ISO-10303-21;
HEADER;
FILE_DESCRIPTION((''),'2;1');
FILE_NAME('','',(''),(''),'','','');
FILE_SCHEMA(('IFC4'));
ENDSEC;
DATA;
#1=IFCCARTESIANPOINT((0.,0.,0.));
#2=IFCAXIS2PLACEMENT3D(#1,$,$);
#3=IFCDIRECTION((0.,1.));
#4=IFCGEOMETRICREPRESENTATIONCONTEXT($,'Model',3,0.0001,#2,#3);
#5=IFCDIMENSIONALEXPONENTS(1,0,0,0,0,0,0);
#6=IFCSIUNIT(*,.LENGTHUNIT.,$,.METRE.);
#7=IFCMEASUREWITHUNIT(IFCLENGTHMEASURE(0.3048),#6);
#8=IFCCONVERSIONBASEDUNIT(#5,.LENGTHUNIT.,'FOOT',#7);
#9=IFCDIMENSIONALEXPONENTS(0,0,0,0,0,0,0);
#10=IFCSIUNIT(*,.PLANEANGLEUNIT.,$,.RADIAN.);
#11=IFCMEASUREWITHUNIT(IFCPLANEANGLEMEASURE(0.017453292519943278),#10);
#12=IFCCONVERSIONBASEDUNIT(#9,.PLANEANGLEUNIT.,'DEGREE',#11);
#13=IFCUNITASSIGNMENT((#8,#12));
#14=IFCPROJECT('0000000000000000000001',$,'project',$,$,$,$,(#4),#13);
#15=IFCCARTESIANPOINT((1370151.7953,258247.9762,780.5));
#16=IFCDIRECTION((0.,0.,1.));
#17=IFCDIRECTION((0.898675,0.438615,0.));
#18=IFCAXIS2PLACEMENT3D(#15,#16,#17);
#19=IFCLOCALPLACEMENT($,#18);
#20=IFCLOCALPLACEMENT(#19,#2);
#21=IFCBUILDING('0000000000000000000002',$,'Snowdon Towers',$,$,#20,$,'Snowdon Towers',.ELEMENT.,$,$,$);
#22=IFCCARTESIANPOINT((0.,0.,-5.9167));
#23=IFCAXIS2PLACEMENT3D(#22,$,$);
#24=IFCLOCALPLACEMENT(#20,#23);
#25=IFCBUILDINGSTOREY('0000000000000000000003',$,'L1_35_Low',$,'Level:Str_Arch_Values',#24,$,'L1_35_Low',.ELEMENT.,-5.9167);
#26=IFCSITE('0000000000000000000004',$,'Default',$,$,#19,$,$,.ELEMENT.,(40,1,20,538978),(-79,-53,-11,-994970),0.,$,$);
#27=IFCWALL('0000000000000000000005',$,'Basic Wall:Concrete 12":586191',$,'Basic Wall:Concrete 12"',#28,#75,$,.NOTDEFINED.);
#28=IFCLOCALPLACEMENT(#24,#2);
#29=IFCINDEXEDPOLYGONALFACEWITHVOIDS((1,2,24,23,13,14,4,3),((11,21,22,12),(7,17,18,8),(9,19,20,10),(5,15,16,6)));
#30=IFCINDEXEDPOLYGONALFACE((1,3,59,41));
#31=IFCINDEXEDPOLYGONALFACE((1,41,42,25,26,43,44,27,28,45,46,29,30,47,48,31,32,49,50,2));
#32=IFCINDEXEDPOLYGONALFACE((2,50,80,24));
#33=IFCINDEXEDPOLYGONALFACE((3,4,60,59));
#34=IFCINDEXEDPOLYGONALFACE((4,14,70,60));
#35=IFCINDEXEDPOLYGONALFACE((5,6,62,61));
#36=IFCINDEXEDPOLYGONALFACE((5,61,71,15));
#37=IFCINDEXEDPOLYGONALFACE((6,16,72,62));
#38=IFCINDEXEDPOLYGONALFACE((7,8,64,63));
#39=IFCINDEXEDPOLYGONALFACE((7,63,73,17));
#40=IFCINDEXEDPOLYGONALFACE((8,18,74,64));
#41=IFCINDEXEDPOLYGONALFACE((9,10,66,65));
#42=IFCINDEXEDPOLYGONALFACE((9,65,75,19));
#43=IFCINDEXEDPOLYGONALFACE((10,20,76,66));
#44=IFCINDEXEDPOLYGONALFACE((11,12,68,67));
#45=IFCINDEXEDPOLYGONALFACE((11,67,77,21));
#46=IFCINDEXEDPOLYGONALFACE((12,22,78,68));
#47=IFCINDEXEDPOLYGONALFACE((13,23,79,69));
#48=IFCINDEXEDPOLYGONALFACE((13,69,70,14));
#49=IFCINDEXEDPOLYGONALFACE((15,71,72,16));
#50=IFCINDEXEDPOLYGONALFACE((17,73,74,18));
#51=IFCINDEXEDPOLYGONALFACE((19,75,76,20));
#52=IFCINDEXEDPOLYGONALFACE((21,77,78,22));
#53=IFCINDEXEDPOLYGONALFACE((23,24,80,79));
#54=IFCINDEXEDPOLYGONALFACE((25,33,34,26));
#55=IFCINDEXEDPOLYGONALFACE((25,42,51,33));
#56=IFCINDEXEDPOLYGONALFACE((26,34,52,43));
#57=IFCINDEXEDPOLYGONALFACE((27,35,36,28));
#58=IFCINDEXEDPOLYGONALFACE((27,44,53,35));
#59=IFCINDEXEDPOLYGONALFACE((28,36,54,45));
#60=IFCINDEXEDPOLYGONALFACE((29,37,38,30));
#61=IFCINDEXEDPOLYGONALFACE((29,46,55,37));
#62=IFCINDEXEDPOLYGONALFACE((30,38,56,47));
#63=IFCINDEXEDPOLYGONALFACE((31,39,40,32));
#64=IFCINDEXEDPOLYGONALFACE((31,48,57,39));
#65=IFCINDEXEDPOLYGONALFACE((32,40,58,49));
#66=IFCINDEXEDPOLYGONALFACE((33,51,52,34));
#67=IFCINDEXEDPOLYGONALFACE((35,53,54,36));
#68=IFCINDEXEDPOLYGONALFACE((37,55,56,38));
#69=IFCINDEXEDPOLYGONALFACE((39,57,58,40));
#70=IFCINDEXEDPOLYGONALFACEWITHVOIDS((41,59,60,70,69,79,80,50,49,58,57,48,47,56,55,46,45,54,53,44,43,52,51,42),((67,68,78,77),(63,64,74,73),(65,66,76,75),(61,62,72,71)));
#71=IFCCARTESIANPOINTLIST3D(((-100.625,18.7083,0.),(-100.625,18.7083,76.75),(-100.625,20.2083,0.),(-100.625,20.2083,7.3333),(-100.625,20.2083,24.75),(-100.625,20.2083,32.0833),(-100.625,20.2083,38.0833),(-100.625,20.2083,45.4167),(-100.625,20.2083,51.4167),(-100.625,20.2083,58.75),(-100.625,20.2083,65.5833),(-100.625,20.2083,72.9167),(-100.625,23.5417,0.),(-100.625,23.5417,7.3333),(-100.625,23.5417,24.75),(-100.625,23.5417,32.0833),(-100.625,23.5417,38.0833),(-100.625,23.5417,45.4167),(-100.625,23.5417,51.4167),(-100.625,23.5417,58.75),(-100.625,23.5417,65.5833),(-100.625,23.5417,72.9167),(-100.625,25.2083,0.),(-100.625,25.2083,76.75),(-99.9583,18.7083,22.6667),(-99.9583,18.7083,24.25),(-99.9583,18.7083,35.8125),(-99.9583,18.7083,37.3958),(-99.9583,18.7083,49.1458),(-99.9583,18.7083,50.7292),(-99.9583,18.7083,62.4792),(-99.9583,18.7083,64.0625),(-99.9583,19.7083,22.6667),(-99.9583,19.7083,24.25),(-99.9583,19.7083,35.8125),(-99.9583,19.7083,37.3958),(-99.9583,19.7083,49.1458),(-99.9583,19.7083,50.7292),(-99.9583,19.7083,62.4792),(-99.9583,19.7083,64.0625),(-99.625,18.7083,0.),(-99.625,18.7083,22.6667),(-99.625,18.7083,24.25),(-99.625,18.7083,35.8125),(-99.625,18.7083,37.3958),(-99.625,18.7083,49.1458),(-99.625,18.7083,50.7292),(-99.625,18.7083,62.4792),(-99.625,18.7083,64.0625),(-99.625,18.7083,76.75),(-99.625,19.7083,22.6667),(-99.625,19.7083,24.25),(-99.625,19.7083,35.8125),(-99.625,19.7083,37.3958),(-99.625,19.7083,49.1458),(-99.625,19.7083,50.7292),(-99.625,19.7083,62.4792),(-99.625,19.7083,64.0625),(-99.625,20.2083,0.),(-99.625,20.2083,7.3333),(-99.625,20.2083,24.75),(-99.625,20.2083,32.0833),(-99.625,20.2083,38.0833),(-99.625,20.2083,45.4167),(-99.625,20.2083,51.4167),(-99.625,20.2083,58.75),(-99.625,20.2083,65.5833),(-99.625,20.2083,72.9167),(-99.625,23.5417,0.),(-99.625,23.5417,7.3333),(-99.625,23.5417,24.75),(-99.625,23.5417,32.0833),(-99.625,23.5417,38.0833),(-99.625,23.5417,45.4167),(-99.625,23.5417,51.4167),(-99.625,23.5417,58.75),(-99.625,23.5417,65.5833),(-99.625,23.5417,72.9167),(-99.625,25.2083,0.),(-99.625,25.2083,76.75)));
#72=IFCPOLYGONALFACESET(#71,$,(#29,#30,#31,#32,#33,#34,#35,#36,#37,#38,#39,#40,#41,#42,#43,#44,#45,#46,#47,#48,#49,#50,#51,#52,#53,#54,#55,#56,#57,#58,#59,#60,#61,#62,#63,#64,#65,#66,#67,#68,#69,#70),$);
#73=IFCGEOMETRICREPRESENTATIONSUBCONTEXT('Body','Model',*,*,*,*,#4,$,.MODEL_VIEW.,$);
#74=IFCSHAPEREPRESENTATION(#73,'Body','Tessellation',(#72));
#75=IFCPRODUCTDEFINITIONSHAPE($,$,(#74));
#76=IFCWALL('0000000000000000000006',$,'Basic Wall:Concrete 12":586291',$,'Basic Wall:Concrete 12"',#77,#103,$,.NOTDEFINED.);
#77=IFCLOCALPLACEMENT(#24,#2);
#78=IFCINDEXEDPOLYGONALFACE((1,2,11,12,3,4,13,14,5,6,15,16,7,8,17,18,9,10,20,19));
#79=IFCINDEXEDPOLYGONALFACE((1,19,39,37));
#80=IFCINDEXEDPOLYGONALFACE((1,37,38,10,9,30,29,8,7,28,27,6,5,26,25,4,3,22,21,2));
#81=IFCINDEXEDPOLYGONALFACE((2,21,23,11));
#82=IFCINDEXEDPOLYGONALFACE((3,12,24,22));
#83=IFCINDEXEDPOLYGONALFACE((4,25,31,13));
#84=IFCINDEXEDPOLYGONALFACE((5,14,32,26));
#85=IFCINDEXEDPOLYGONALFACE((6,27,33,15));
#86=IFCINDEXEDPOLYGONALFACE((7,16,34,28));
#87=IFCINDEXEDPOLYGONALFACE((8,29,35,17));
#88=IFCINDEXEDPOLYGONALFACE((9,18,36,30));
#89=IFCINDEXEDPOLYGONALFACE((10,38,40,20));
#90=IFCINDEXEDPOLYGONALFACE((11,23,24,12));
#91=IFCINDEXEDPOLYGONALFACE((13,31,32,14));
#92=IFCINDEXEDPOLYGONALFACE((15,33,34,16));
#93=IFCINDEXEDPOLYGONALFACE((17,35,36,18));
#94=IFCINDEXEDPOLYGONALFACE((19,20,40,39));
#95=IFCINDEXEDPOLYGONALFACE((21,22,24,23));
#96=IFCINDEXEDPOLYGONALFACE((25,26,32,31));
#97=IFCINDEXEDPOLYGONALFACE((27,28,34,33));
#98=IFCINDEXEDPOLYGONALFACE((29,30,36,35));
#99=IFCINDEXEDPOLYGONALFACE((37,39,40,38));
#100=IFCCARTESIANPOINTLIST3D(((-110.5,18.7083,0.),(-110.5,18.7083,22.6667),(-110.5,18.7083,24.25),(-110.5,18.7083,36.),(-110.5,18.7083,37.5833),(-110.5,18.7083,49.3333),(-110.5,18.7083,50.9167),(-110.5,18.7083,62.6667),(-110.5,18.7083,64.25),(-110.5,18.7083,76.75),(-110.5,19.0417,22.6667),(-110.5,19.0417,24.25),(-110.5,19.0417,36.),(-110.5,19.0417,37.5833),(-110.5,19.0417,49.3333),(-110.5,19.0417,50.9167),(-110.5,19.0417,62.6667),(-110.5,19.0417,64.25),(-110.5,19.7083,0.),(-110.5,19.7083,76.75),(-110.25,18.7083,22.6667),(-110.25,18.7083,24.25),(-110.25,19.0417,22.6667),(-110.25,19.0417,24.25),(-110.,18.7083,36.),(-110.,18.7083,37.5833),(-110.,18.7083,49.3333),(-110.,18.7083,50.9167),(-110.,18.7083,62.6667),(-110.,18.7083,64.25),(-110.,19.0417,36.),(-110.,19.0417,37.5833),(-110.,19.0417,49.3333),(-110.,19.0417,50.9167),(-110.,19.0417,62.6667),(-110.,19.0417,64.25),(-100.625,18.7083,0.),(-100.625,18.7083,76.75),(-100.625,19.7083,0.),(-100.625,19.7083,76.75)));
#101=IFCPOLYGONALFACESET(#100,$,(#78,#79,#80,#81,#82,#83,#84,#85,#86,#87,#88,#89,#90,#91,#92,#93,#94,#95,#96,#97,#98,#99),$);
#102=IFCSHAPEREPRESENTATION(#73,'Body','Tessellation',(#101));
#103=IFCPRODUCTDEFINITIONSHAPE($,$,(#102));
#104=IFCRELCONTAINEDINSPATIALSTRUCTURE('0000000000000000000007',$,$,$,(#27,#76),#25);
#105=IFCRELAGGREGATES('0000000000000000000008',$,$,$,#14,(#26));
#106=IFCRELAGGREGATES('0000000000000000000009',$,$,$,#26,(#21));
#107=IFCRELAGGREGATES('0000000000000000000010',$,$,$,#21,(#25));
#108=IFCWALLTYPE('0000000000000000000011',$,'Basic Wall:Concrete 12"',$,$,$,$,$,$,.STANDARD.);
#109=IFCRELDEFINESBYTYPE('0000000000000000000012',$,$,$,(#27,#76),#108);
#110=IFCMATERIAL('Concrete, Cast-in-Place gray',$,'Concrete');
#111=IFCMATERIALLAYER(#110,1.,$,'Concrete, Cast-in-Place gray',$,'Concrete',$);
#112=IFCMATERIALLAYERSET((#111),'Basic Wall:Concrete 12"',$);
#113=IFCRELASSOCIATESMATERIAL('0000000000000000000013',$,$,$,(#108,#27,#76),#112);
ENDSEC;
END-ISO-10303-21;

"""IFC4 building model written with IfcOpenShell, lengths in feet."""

from ifc_helpers import new_model, entity, si_unit, converted_unit, direction, frame, frame_2d, origin, place, context, subcontext, project, spatial, rectangle, extrude, material, layer, layer_set, layer_usage, type_object, element, save


model = new_model("IFC4")

# Units and contexts
model_context = context("Model", 3, precision=0.0001, world=origin(), true_north=direction((0.0, 1.0)))
body_context = subcontext(model_context, "Body", "Model", "MODEL_VIEW")
ifc_project = project(units=[converted_unit("LENGTHUNIT", "FOOT", entity("IfcLengthMeasure", 0.3048), si_unit("LENGTHUNIT", "METRE"), dimensions=[1, 0, 0, 0, 0, 0, 0]), converted_unit("PLANEANGLEUNIT", "DEGREE", entity("IfcPlaneAngleMeasure", 0.017453292519943278), si_unit("PLANEANGLEUNIT", "RADIAN"), dimensions=[0, 0, 0, 0, 0, 0, 0])], contexts=[model_context])

# Site, building, storey
site_placement = place(None, frame((1370151.7953, 258247.9762, 780.5), z_axis=(0.0, 0.0, 1.0), x_axis=(0.898675, 0.438615, 0.0)))
site = spatial("IfcSite", under=ifc_project, at=site_placement, Name="Default", CompositionType="ELEMENT", RefLatitude=(40, 1, 20, 538978), RefLongitude=(-79, -53, -11, -994970), RefElevation=0.0)
building_placement = place(site_placement, origin())
building = spatial("IfcBuilding", under=site, at=building_placement, Name="Snowdon Towers", LongName="Snowdon Towers", CompositionType="ELEMENT")
storey_placement = place(building_placement, frame((0.0, 0.0, -5.9167)))
storey = spatial("IfcBuildingStorey", under=building, at=storey_placement, Name="L1_35_Low", ObjectType="Level:Str_Arch_Values", LongName="L1_35_Low", CompositionType="ELEMENT", Elevation=-5.9167)

# Walls, openings
ifc_material = material(Name="Concrete, Cast-in-Place gray", Category="Concrete")
ifc_layer = layer(ifc_material, 1.0, Name="Concrete, Cast-in-Place gray", Category="Concrete")
ifc_layer_set = layer_set([ifc_layer], Name="Basic Wall:Concrete 12\"")
ifc_layer_usage_1 = layer_usage(ifc_layer_set, "AXIS2", "POSITIVE", -0.5)
wall_type = type_object("IfcWallType", Name="Basic Wall:Concrete 12\"", PredefinedType="STANDARD", material=ifc_layer_set)
wall_1_placement = place(storey_placement, frame((-100.125, 25.2083, 0.0), z_axis=(0.0, 0.0, 1.0), x_axis=(0.0, -1.0, 0.0)))
wall_1 = element("IfcWall", 1, at=wall_1_placement, inside=storey, type_object=wall_type, material=ifc_layer_usage_1, Name="Basic Wall:Concrete 12\":586191", ObjectType="Basic Wall:Concrete 12\"", PredefinedType="NOTDEFINED", context=body_context, shape_type="SweptSolid", body=[
    extrude(rectangle(XDim=6.5, YDim=1.0, at=frame_2d((3.25, 0.0), x_axis=(1.0, 0.0))), origin(), (0.0, 0.0, 1.0), 76.75),
])
opening_1_placement = place(wall_1_placement, origin())
element("IfcOpeningElement", 2, at=opening_1_placement, cuts=wall_1, PredefinedType="OPENING", context=body_context, shape_type="SweptSolid", body=[
    extrude(rectangle(XDim=7.3333, YDim=3.3333, at=frame_2d((0.0, 0.0), x_axis=(1.0, 0.0))), frame((3.3333, -4.5, 3.6667), z_axis=(0.0, 1.0, 0.0), x_axis=(0.0, 0.0, 1.0)), (0.0, 0.0, 1.0), 10.0),
])
opening_2_placement = place(wall_1_placement, origin())
element("IfcOpeningElement", 3, at=opening_2_placement, cuts=wall_1, PredefinedType="RECESS", context=body_context, shape_type="SweptSolid", body=[
    extrude(rectangle(XDim=1.5833, YDim=1.0, at=frame_2d((0.0, 0.0), x_axis=(0.0, 1.0))), frame((6.0, 0.1667, 23.4583), z_axis=(0.0, 1.0, 0.0), x_axis=(1.0, 0.0, 0.0)), (0.0, 0.0, 1.0), 0.3333),
])
opening_3_placement = place(wall_1_placement, origin())
element("IfcOpeningElement", 4, at=opening_3_placement, cuts=wall_1, PredefinedType="RECESS", context=body_context, shape_type="SweptSolid", body=[
    extrude(rectangle(XDim=1.5833, YDim=1.0, at=frame_2d((0.0, 0.0), x_axis=(0.0, 1.0))), frame((6.0, 0.1667, 63.2708), z_axis=(0.0, 1.0, 0.0), x_axis=(1.0, 0.0, 0.0)), (0.0, 0.0, 1.0), 0.3333),
])
opening_4_placement = place(wall_1_placement, origin())
element("IfcOpeningElement", 5, at=opening_4_placement, cuts=wall_1, PredefinedType="RECESS", context=body_context, shape_type="SweptSolid", body=[
    extrude(rectangle(XDim=1.5833, YDim=1.0, at=frame_2d((0.0, 0.0), x_axis=(0.0, 1.0))), frame((6.0, 0.1667, 36.6042), z_axis=(0.0, 1.0, 0.0), x_axis=(1.0, 0.0, 0.0)), (0.0, 0.0, 1.0), 0.3333),
])
opening_5_placement = place(wall_1_placement, origin())
element("IfcOpeningElement", 6, at=opening_5_placement, cuts=wall_1, PredefinedType="RECESS", context=body_context, shape_type="SweptSolid", body=[
    extrude(rectangle(XDim=1.5833, YDim=1.0, at=frame_2d((0.0, 0.0), x_axis=(0.0, 1.0))), frame((6.0, 0.1667, 49.9375), z_axis=(0.0, 1.0, 0.0), x_axis=(1.0, 0.0, 0.0)), (0.0, 0.0, 1.0), 0.3333),
])
opening_6_placement = place(wall_1_placement, origin())
element("IfcOpeningElement", 7, at=opening_6_placement, cuts=wall_1, PredefinedType="OPENING", context=body_context, shape_type="SweptSolid", body=[
    extrude(rectangle(XDim=7.3333, YDim=3.3333, at=frame_2d((0.0, 0.0), x_axis=(1.0, 0.0))), frame((3.3333, -4.5, 28.4167), z_axis=(0.0, 1.0, 0.0), x_axis=(0.0, 0.0, 1.0)), (0.0, 0.0, 1.0), 10.0),
])
opening_7_placement = place(wall_1_placement, origin())
element("IfcOpeningElement", 8, at=opening_7_placement, cuts=wall_1, PredefinedType="OPENING", context=body_context, shape_type="SweptSolid", body=[
    extrude(rectangle(XDim=7.3333, YDim=3.3333, at=frame_2d((0.0, 0.0), x_axis=(1.0, 0.0))), frame((3.3333, -4.5, 41.75), z_axis=(0.0, 1.0, 0.0), x_axis=(0.0, 0.0, 1.0)), (0.0, 0.0, 1.0), 10.0),
])
opening_8_placement = place(wall_1_placement, origin())
element("IfcOpeningElement", 9, at=opening_8_placement, cuts=wall_1, PredefinedType="OPENING", context=body_context, shape_type="SweptSolid", body=[
    extrude(rectangle(XDim=7.3333, YDim=3.3333, at=frame_2d((0.0, 0.0), x_axis=(1.0, 0.0))), frame((3.3333, -4.5, 55.0833), z_axis=(0.0, 1.0, 0.0), x_axis=(0.0, 0.0, 1.0)), (0.0, 0.0, 1.0), 10.0),
])
opening_9_placement = place(wall_1_placement, origin())
element("IfcOpeningElement", 10, at=opening_9_placement, cuts=wall_1, PredefinedType="OPENING", context=body_context, shape_type="SweptSolid", body=[
    extrude(rectangle(XDim=7.3333, YDim=3.3333, at=frame_2d((0.0, 0.0), x_axis=(1.0, 0.0))), frame((3.3333, -4.5, 69.25), z_axis=(0.0, 1.0, 0.0), x_axis=(0.0, 0.0, 1.0)), (0.0, 0.0, 1.0), 10.0),
])
ifc_layer_usage_2 = layer_usage(ifc_layer_set, "AXIS2", "POSITIVE", -0.5)
wall_2_placement = place(storey_placement, frame((-100.625, 19.2083, 0.0), z_axis=(0.0, 0.0, 1.0), x_axis=(-1.0, 0.0, 0.0)))
wall_2 = element("IfcWall", 11, at=wall_2_placement, inside=storey, type_object=wall_type, material=ifc_layer_usage_2, Name="Basic Wall:Concrete 12\":586291", ObjectType="Basic Wall:Concrete 12\"", PredefinedType="NOTDEFINED", context=body_context, shape_type="SweptSolid", body=[
    extrude(rectangle(XDim=9.875, YDim=1.0, at=frame_2d((4.9375, 0.0), x_axis=(-1.0, 0.0))), origin(), (0.0, 0.0, 1.0), 76.75),
])
opening_10_placement = place(wall_2_placement, origin())
element("IfcOpeningElement", 12, at=opening_10_placement, cuts=wall_2, PredefinedType="RECESS", context=body_context, shape_type="SweptSolid", body=[
    extrude(rectangle(XDim=1.5833, YDim=1.0, at=frame_2d((0.0, 0.0), x_axis=(0.0, 1.0))), frame((10.125, 0.1667, 23.4583), z_axis=(0.0, 1.0, 0.0), x_axis=(1.0, 0.0, 0.0)), (0.0, 0.0, 1.0), 0.3333),
])
opening_11_placement = place(wall_2_placement, origin())
element("IfcOpeningElement", 13, at=opening_11_placement, cuts=wall_2, PredefinedType="RECESS", context=body_context, shape_type="SweptSolid", body=[
    extrude(rectangle(XDim=1.5833, YDim=1.0, at=frame_2d((0.0, 0.0), x_axis=(0.0, 1.0))), frame((9.875, 0.1667, 63.4583), z_axis=(0.0, 1.0, 0.0), x_axis=(1.0, 0.0, 0.0)), (0.0, 0.0, 1.0), 0.3333),
])
opening_12_placement = place(wall_2_placement, origin())
element("IfcOpeningElement", 14, at=opening_12_placement, cuts=wall_2, PredefinedType="RECESS", context=body_context, shape_type="SweptSolid", body=[
    extrude(rectangle(XDim=1.5833, YDim=1.0, at=frame_2d((0.0, 0.0), x_axis=(0.0, 1.0))), frame((9.875, 0.1667, 36.7917), z_axis=(0.0, 1.0, 0.0), x_axis=(1.0, 0.0, 0.0)), (0.0, 0.0, 1.0), 0.3333),
])
opening_13_placement = place(wall_2_placement, origin())
element("IfcOpeningElement", 15, at=opening_13_placement, cuts=wall_2, PredefinedType="RECESS", context=body_context, shape_type="SweptSolid", body=[
    extrude(rectangle(XDim=1.5833, YDim=1.0, at=frame_2d((0.0, 0.0), x_axis=(0.0, 1.0))), frame((9.875, 0.1667, 50.125), z_axis=(0.0, 1.0, 0.0), x_axis=(1.0, 0.0, 0.0)), (0.0, 0.0, 1.0), 0.3333),
])
opening_14_placement = place(wall_2_placement, origin())
element("IfcOpeningElement", 16, at=opening_14_placement, cuts=wall_2, PredefinedType="OPENING", context=body_context, shape_type="SweptSolid", body=[
    extrude(rectangle(XDim=1.5833, YDim=0.3333, at=frame_2d((0.0, 0.0), x_axis=(0.0, 1.0))), frame((-0.8333, -0.5, 23.4583), z_axis=(0.0, 1.0, 0.0), x_axis=(-1.0, 0.0, 0.0)), (0.0, 0.0, 1.0), 1.0),
])
opening_15_placement = place(wall_2_placement, origin())
element("IfcOpeningElement", 17, at=opening_15_placement, cuts=wall_2, PredefinedType="OPENING", context=body_context, shape_type="SweptSolid", body=[
    extrude(rectangle(XDim=1.5833, YDim=0.3333, at=frame_2d((0.0, 0.0), x_axis=(0.0, 1.0))), frame((-0.8333, -0.5, 63.2708), z_axis=(0.0, 1.0, 0.0), x_axis=(-1.0, 0.0, 0.0)), (0.0, 0.0, 1.0), 1.0),
])
opening_16_placement = place(wall_2_placement, origin())
element("IfcOpeningElement", 18, at=opening_16_placement, cuts=wall_2, PredefinedType="OPENING", context=body_context, shape_type="SweptSolid", body=[
    extrude(rectangle(XDim=1.5833, YDim=0.3333, at=frame_2d((0.0, 0.0), x_axis=(0.0, 1.0))), frame((-0.8333, -0.5, 36.6042), z_axis=(0.0, 1.0, 0.0), x_axis=(-1.0, 0.0, 0.0)), (0.0, 0.0, 1.0), 1.0),
])
opening_17_placement = place(wall_2_placement, origin())
element("IfcOpeningElement", 19, at=opening_17_placement, cuts=wall_2, PredefinedType="OPENING", context=body_context, shape_type="SweptSolid", body=[
    extrude(rectangle(XDim=1.5833, YDim=0.3333, at=frame_2d((0.0, 0.0), x_axis=(0.0, 1.0))), frame((-0.8333, -0.5, 49.9375), z_axis=(0.0, 1.0, 0.0), x_axis=(-1.0, 0.0, 0.0)), (0.0, 0.0, 1.0), 1.0),
])

save(model, "model.ifc")
